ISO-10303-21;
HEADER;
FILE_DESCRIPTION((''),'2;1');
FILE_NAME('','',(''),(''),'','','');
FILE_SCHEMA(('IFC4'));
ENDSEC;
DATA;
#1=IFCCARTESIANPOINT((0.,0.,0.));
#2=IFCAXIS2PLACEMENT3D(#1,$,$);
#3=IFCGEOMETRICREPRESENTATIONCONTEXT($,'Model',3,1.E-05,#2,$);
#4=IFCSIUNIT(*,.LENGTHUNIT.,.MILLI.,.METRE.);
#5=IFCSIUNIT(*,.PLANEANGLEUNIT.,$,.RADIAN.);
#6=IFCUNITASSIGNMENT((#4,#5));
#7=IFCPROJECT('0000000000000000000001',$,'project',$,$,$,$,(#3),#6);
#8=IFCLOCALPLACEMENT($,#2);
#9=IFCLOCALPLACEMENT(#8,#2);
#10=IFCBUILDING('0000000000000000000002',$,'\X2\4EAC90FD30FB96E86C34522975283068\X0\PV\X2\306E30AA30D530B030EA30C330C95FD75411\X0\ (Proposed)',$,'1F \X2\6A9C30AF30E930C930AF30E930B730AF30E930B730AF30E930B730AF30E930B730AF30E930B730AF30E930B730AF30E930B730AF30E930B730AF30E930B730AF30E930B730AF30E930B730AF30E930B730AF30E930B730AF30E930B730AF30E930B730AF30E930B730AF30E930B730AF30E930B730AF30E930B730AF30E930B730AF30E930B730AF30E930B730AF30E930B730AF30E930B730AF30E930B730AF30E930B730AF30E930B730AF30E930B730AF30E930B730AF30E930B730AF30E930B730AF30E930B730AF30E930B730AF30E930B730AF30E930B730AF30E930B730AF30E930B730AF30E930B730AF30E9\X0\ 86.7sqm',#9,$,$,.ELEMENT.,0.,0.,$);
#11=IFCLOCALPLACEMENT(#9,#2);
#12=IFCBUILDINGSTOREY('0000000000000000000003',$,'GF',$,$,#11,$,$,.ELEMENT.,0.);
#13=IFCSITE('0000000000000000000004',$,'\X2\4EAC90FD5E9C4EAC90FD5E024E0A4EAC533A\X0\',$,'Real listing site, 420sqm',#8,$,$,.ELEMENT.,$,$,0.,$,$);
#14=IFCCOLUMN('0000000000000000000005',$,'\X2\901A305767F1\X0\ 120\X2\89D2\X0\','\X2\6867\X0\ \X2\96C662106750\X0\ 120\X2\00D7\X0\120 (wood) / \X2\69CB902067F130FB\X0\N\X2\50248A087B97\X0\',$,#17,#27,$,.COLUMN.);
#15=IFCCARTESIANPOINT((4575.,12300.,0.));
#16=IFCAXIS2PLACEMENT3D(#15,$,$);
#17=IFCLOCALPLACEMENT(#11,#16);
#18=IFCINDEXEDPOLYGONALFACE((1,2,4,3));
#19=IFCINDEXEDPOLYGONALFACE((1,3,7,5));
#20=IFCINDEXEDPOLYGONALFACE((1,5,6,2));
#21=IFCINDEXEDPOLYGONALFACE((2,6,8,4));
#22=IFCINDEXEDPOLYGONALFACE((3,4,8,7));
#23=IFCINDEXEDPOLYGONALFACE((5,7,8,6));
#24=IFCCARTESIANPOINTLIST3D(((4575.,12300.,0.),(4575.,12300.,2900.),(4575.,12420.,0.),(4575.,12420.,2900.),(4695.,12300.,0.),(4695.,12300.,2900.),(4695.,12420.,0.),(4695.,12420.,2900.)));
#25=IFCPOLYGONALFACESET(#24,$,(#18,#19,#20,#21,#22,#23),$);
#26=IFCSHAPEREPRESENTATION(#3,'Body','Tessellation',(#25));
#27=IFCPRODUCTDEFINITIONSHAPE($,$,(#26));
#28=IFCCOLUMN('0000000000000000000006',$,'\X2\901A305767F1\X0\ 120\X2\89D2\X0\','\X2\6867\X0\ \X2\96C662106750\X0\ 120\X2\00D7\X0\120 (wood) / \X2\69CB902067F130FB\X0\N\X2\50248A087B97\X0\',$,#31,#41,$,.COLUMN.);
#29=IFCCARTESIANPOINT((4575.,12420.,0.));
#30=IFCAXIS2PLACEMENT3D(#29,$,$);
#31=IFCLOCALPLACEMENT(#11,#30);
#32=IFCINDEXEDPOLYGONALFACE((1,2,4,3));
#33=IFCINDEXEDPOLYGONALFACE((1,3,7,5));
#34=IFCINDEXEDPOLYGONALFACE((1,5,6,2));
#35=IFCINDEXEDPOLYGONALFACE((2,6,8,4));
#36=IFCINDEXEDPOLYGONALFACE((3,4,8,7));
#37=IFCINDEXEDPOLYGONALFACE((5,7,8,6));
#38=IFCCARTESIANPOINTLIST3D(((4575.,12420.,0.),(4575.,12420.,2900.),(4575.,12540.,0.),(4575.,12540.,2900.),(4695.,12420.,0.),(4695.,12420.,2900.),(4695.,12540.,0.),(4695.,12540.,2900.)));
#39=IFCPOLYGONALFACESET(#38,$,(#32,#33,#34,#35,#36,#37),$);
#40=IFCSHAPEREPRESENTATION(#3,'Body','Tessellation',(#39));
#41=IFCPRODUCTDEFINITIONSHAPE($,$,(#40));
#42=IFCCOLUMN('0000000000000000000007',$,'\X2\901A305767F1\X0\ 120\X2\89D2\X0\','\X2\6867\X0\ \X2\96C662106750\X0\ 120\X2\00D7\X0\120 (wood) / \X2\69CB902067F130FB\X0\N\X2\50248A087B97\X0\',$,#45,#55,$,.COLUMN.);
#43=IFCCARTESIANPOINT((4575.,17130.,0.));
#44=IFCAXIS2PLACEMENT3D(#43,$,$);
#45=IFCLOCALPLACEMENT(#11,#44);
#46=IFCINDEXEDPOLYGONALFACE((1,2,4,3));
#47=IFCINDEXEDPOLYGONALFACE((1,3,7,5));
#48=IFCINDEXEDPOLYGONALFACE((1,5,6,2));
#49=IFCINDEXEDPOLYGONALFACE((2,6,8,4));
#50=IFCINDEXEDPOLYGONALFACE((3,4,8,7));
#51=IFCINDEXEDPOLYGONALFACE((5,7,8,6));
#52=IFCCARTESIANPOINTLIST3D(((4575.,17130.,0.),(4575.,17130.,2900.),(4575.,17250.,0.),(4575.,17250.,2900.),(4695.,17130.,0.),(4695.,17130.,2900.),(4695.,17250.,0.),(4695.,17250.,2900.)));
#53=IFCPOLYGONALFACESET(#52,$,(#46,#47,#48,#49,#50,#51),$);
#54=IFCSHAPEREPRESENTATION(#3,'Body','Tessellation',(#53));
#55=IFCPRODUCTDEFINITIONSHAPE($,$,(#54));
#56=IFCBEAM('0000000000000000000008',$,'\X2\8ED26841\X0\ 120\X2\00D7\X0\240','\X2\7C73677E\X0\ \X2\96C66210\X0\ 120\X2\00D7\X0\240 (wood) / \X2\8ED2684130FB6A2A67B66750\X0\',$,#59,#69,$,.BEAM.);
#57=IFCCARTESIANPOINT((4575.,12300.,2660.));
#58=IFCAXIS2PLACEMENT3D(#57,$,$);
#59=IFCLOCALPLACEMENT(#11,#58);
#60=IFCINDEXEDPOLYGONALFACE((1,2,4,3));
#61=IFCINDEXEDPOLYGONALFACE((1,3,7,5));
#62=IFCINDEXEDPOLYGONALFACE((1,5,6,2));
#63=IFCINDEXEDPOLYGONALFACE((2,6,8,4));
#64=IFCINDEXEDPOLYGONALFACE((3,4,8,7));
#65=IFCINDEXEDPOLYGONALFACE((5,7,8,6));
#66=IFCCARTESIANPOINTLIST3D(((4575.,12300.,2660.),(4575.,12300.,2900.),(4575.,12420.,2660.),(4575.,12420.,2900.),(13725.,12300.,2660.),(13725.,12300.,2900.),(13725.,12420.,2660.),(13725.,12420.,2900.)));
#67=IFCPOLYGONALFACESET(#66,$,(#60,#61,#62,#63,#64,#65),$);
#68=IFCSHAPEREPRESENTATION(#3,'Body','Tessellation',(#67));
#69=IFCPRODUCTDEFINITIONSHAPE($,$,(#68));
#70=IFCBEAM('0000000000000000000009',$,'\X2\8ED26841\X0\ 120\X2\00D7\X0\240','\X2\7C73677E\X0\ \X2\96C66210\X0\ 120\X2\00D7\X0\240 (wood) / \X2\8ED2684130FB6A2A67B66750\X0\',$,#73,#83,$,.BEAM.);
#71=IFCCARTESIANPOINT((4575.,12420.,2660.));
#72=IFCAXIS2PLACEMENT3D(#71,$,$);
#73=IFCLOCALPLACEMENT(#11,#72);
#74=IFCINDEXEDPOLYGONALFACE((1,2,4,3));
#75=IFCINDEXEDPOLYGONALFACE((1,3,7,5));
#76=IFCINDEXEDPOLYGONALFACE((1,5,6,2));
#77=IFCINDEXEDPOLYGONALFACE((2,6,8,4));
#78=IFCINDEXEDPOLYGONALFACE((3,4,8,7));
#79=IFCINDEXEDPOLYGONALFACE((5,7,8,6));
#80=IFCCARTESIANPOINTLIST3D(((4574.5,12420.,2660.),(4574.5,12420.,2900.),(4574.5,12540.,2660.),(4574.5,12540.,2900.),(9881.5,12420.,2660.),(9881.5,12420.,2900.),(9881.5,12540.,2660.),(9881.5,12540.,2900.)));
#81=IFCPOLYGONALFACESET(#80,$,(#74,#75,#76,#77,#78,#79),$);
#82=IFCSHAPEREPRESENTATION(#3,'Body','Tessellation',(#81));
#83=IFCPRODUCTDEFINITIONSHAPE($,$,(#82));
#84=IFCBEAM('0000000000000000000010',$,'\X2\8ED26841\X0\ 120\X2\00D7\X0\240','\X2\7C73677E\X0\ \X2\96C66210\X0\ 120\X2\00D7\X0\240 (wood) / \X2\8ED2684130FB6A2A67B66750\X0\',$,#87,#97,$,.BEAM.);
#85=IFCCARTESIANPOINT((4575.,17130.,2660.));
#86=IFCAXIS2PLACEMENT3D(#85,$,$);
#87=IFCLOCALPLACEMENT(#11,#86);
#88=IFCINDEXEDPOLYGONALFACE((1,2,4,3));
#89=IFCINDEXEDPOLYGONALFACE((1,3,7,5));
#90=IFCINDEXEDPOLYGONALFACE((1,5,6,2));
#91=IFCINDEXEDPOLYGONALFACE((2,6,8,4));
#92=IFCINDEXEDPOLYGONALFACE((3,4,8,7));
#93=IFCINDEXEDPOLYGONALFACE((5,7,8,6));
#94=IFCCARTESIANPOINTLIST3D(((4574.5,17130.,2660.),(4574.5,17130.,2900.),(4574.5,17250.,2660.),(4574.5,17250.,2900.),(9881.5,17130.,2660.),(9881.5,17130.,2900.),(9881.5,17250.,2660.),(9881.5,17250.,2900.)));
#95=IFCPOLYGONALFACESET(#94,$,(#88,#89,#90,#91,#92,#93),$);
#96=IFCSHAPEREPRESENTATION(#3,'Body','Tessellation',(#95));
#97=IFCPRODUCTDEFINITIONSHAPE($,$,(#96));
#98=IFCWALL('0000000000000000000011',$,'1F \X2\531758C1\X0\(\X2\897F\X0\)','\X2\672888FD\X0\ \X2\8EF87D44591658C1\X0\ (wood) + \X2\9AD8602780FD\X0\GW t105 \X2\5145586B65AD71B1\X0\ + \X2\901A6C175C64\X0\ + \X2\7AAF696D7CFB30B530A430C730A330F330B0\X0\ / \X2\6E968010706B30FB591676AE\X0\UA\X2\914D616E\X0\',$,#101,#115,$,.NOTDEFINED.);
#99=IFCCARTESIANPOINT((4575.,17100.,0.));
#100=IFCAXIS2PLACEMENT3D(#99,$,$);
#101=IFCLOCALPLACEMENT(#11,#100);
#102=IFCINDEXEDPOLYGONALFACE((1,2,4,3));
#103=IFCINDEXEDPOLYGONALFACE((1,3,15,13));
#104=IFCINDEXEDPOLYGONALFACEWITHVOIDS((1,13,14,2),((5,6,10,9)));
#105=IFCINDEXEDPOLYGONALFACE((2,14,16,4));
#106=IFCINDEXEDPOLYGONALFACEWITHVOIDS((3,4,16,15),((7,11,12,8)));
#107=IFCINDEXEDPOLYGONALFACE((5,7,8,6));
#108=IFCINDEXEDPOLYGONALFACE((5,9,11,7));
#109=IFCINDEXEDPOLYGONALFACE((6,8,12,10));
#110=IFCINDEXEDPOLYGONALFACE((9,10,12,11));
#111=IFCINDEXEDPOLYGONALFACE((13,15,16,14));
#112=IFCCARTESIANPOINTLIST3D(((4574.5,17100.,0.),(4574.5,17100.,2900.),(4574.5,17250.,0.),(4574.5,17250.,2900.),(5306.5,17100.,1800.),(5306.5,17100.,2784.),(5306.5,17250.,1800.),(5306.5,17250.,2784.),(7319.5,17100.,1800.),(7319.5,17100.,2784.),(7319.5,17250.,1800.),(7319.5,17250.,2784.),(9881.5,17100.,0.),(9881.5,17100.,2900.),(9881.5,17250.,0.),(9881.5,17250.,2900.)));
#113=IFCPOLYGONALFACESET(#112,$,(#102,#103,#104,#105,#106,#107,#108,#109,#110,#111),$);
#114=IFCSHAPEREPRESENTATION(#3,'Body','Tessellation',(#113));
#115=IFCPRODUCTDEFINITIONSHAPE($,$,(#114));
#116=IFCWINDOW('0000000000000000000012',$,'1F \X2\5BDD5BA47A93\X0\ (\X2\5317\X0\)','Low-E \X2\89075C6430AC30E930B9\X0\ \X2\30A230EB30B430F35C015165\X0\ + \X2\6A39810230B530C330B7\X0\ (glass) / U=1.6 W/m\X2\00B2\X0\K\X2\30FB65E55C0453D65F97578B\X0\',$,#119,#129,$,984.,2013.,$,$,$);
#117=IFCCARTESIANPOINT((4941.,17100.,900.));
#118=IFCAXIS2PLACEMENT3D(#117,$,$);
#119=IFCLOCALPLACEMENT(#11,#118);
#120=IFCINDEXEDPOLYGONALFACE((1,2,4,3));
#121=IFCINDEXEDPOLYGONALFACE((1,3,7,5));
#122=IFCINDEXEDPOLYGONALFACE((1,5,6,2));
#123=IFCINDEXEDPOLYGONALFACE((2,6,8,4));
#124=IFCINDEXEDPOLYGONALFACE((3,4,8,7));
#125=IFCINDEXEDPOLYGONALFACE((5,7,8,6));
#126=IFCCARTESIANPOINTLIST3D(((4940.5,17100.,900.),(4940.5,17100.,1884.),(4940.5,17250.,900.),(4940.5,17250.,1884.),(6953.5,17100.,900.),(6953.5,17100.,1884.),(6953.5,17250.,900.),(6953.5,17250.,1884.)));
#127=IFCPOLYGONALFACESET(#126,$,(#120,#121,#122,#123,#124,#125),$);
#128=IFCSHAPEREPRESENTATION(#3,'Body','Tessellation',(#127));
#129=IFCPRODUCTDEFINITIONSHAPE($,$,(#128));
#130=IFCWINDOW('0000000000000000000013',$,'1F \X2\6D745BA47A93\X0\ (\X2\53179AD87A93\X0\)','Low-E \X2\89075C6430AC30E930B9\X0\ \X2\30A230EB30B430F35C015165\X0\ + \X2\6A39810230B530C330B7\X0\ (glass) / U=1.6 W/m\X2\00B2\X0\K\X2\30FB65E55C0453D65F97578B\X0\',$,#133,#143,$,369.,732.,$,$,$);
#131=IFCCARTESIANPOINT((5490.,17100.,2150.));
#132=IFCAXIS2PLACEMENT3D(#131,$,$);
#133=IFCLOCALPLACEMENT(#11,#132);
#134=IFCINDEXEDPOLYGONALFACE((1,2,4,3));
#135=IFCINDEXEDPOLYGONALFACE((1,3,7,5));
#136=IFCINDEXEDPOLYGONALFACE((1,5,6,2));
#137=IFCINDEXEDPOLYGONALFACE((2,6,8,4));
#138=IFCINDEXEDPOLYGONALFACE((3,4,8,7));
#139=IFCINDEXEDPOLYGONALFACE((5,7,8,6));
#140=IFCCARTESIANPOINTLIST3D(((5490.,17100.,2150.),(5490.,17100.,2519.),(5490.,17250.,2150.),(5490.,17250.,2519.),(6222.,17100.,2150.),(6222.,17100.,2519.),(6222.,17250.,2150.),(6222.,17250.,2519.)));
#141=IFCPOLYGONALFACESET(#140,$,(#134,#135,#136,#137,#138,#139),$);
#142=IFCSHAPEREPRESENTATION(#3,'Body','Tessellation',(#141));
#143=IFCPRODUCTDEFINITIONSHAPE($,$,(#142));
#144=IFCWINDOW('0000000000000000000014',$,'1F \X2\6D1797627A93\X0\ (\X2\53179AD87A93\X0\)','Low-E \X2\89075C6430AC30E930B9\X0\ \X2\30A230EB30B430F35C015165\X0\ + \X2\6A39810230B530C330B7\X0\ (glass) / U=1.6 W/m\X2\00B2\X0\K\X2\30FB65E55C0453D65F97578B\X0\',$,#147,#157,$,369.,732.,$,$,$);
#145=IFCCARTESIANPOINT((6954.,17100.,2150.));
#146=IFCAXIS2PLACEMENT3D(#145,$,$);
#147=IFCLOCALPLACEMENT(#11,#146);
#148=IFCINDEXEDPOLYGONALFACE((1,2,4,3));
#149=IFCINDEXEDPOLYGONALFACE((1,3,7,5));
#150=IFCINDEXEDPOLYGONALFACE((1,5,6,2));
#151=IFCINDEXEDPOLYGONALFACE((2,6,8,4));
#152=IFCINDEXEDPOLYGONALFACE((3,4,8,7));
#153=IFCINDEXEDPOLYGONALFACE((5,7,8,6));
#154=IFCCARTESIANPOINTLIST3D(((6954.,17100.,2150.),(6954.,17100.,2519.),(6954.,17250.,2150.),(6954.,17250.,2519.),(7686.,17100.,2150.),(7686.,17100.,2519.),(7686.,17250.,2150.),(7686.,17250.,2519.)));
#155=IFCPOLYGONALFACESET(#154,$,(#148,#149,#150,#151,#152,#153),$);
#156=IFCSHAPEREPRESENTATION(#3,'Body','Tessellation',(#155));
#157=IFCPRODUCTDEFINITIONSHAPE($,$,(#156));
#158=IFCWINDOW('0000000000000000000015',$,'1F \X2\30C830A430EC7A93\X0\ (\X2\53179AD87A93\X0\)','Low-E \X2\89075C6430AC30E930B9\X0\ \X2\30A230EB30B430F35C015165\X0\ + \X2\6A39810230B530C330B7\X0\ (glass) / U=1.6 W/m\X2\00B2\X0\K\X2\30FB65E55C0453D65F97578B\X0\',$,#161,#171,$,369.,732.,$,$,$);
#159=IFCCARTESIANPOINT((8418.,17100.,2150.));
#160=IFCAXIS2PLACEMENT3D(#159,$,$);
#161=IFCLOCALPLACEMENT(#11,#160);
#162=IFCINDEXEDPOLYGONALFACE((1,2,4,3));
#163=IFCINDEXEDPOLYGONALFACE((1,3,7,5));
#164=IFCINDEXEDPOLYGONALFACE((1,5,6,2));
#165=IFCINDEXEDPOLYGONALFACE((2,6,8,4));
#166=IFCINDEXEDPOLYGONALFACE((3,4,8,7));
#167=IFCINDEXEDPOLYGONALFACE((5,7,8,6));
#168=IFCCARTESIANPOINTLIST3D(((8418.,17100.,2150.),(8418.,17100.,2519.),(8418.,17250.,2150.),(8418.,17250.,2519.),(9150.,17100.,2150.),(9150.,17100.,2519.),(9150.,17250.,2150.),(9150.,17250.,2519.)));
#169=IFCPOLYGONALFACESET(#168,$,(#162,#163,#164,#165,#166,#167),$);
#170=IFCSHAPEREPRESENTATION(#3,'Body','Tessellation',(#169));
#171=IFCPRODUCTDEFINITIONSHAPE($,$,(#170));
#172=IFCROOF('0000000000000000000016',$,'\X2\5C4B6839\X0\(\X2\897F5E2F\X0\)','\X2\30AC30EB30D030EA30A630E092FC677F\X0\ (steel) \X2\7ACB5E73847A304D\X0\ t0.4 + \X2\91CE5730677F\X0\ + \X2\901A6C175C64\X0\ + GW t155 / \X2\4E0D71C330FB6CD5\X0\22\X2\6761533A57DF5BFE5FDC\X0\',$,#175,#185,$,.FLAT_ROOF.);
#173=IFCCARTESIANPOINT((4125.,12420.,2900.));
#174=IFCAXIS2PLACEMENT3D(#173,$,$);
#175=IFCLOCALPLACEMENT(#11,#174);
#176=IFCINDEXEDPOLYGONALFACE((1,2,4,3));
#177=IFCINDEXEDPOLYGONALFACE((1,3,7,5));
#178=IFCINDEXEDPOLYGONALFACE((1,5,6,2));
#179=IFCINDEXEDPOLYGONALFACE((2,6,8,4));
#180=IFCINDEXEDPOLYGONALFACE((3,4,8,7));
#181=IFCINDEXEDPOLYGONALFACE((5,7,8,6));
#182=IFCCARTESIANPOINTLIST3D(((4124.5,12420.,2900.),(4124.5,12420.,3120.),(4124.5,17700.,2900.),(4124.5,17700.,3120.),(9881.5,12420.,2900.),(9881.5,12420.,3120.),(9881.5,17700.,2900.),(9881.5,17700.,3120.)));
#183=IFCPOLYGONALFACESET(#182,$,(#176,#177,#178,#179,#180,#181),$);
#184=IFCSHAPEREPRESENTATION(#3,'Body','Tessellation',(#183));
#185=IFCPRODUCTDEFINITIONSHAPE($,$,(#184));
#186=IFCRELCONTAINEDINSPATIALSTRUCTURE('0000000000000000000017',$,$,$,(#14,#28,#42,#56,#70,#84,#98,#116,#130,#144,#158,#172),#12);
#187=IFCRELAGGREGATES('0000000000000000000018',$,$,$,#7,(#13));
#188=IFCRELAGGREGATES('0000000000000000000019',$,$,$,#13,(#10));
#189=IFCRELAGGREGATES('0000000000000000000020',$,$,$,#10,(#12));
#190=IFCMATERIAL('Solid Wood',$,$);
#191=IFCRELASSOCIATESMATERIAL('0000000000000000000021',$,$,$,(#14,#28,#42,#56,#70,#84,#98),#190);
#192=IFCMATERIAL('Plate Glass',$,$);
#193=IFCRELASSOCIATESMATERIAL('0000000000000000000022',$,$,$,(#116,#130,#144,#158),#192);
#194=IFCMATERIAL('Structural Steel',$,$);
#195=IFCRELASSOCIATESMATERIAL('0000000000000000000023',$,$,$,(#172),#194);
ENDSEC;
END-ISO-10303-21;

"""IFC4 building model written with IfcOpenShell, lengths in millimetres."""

from ifc_helpers import new_model, si_unit, frame, frame_2d, origin, place, context, project, spatial, rectangle, extrude, material, element, fill, save


model = new_model("IFC4")

# Units and contexts
model_context = context("Model", 3, precision=1e-05, world=origin())
ifc_project = project(units=[si_unit("LENGTHUNIT", "METRE", prefix="MILLI"), si_unit("PLANEANGLEUNIT", "RADIAN")], contexts=[model_context])

# Site, building, storey
site_placement = place(None, origin())
site = spatial("IfcSite", under=ifc_project, at=site_placement, Name="京都府京都市上京区", ObjectType="Real listing site, 420sqm", CompositionType="ELEMENT", RefElevation=0.0)
building_placement = place(site_placement, origin())
building = spatial("IfcBuilding", under=site, at=building_placement, Name="京都・雨水利用とPVのオフグリッド志向 (Proposed)", ObjectType="1F 檜クラドクラシクラシクラシクラシクラシクラシクラシクラシクラシクラシクラシクラシクラシクラシクラシクラシクラシクラシクラシクラシクラシクラシクラシクラシクラシクラシクラシクラシクラシクラシクラシクラシクラシクラシクラシクラシクラシクラシクラ 86.7sqm", CompositionType="ELEMENT", ElevationOfRefHeight=0.0, ElevationOfTerrain=0.0)
storey_placement = place(building_placement, origin())
storey = spatial("IfcBuildingStorey", under=building, at=storey_placement, Name="GF", CompositionType="ELEMENT", Elevation=0.0)

# Columns
ifc_material_1 = material(Name="Solid Wood")
column_1_placement = place(storey_placement, frame((4575.0, 12300.0, 0.0)))
element("IfcColumn", 1, at=column_1_placement, inside=storey, material=ifc_material_1, Name="通し柱 120角", Description="桧 集成材 120×120 (wood) / 構造柱・N値計算", PredefinedType="COLUMN", context=model_context, shape_type="SweptSolid", body=[
    extrude(rectangle(XDim=120.0, YDim=120.0, at=frame_2d((60.0, 60.0))), frame((4575.0, 12300.0, 0.0)), (0.0, 0.0, 1.0), 2900.0),
])
column_2_placement = place(storey_placement, frame((4575.0, 12420.0, 0.0)))
element("IfcColumn", 2, at=column_2_placement, inside=storey, material=ifc_material_1, Name="通し柱 120角", Description="桧 集成材 120×120 (wood) / 構造柱・N値計算", PredefinedType="COLUMN", context=model_context, shape_type="SweptSolid", body=[
    extrude(rectangle(XDim=120.0, YDim=120.0, at=frame_2d((60.0, 60.0))), frame((4575.0, 12420.0, 0.0)), (0.0, 0.0, 1.0), 2900.0),
])
column_3_placement = place(storey_placement, frame((4575.0, 17130.0, 0.0)))
element("IfcColumn", 3, at=column_3_placement, inside=storey, material=ifc_material_1, Name="通し柱 120角", Description="桧 集成材 120×120 (wood) / 構造柱・N値計算", PredefinedType="COLUMN", context=model_context, shape_type="SweptSolid", body=[
    extrude(rectangle(XDim=120.0, YDim=120.0, at=frame_2d((60.0, 60.0))), frame((4575.0, 17130.0, 0.0)), (0.0, 0.0, 1.0), 2900.0),
])

# Beams
beam_1_placement = place(storey_placement, frame((4575.0, 12300.0, 2660.0)))
element("IfcBeam", 4, at=beam_1_placement, inside=storey, material=ifc_material_1, Name="軒桁 120×240", Description="米松 集成 120×240 (wood) / 軒桁・横架材", PredefinedType="BEAM", context=model_context, shape_type="SweptSolid", body=[
    extrude(rectangle(XDim=9150.0, YDim=120.0, at=frame_2d((4575.0, 60.0))), frame((4575.0, 12300.0, 2660.0)), (0.0, 0.0, 1.0), 240.0),
])
beam_2_placement = place(storey_placement, frame((4575.0, 12420.0, 2660.0)))
element("IfcBeam", 5, at=beam_2_placement, inside=storey, material=ifc_material_1, Name="軒桁 120×240", Description="米松 集成 120×240 (wood) / 軒桁・横架材", PredefinedType="BEAM", context=model_context, shape_type="SweptSolid", body=[
    extrude(rectangle(XDim=5307.0, YDim=120.0, at=frame_2d((2653.0, 60.0))), frame((4575.0, 12420.0, 2660.0)), (0.0, 0.0, 1.0), 240.0),
])
beam_3_placement = place(storey_placement, frame((4575.0, 17130.0, 2660.0)))
element("IfcBeam", 6, at=beam_3_placement, inside=storey, material=ifc_material_1, Name="軒桁 120×240", Description="米松 集成 120×240 (wood) / 軒桁・横架材", PredefinedType="BEAM", context=model_context, shape_type="SweptSolid", body=[
    extrude(rectangle(XDim=5307.0, YDim=120.0, at=frame_2d((2653.0, 60.0))), frame((4575.0, 17130.0, 2660.0)), (0.0, 0.0, 1.0), 240.0),
])

# Wall, openings, windows
wall_1_placement = place(storey_placement, frame((4575.0, 17100.0, 0.0)))
wall_1 = element("IfcWall", 7, at=wall_1_placement, inside=storey, material=ifc_material_1, Name="1F 北壁(西)", Description="木製 軸組外壁 (wood) + 高性能GW t105 充填断熱 + 通気層 + 窯業系サイディング / 準耐火・外皮UA配慮", PredefinedType="NOTDEFINED", context=model_context, shape_type="SweptSolid", body=[
    extrude(rectangle(XDim=5307.0, YDim=150.0, at=frame_2d((2653.0, 75.0))), frame((4575.0, 17100.0, 0.0)), (0.0, 0.0, 1.0), 2900.0),
])
opening_1_placement = place(storey_placement, frame((4941.0, 17100.0, 900.0)))
opening_1 = element("IfcOpeningElement", 8, at=opening_1_placement, cuts=wall_1, PredefinedType="NOTDEFINED", context=model_context, shape_type="SweptSolid", body=[
    extrude(rectangle(XDim=2013.0, YDim=150.0, at=frame_2d((1006.0, 75.0))), frame((4941.0, 17100.0, 900.0)), (0.0, 0.0, 1.0), 984.0),
])
opening_2_placement = place(storey_placement, frame((5490.0, 17100.0, 2150.0)))
opening_2 = element("IfcOpeningElement", 9, at=opening_2_placement, cuts=wall_1, PredefinedType="NOTDEFINED", context=model_context, shape_type="SweptSolid", body=[
    extrude(rectangle(XDim=732.0, YDim=150.0, at=frame_2d((366.0, 75.0))), frame((5490.0, 17100.0, 2150.0)), (0.0, 0.0, 1.0), 369.0),
])
opening_3_placement = place(storey_placement, frame((6954.0, 17100.0, 2150.0)))
opening_3 = element("IfcOpeningElement", 10, at=opening_3_placement, cuts=wall_1, PredefinedType="NOTDEFINED", context=model_context, shape_type="SweptSolid", body=[
    extrude(rectangle(XDim=732.0, YDim=150.0, at=frame_2d((366.0, 75.0))), frame((6954.0, 17100.0, 2150.0)), (0.0, 0.0, 1.0), 369.0),
])
opening_4_placement = place(storey_placement, frame((8418.0, 17100.0, 2150.0)))
opening_4 = element("IfcOpeningElement", 11, at=opening_4_placement, cuts=wall_1, PredefinedType="NOTDEFINED", context=model_context, shape_type="SweptSolid", body=[
    extrude(rectangle(XDim=732.0, YDim=150.0, at=frame_2d((366.0, 75.0))), frame((8418.0, 17100.0, 2150.0)), (0.0, 0.0, 1.0), 369.0),
])
ifc_material_2 = material(Name="Plate Glass")
window_1_placement = place(storey_placement, frame((4941.0, 17100.0, 900.0)))
window_1 = element("IfcWindow", 12, at=window_1_placement, inside=storey, material=ifc_material_2, Name="1F 寝室窓 (北)", Description="Low-E 複層ガラス アルゴン封入 + 樹脂サッシ (glass) / U=1.6 W/m²K・日射取得型", OverallHeight=984.0, OverallWidth=2013.0, context=model_context, shape_type="SweptSolid", body=[
    extrude(rectangle(XDim=2013.0, YDim=150.0, at=frame_2d((1006.0, 75.0))), frame((4941.0, 17100.0, 900.0)), (0.0, 0.0, 1.0), 984.0),
])
fill(opening_1, window_1)
window_2_placement = place(storey_placement, frame((5490.0, 17100.0, 2150.0)))
window_2 = element("IfcWindow", 13, at=window_2_placement, inside=storey, material=ifc_material_2, Name="1F 浴室窓 (北高窓)", Description="Low-E 複層ガラス アルゴン封入 + 樹脂サッシ (glass) / U=1.6 W/m²K・日射取得型", OverallHeight=369.0, OverallWidth=732.0, context=model_context, shape_type="SweptSolid", body=[
    extrude(rectangle(XDim=732.0, YDim=150.0, at=frame_2d((366.0, 75.0))), frame((5490.0, 17100.0, 2150.0)), (0.0, 0.0, 1.0), 369.0),
])
fill(opening_2, window_2)
window_3_placement = place(storey_placement, frame((6954.0, 17100.0, 2150.0)))
window_3 = element("IfcWindow", 14, at=window_3_placement, inside=storey, material=ifc_material_2, Name="1F 洗面窓 (北高窓)", Description="Low-E 複層ガラス アルゴン封入 + 樹脂サッシ (glass) / U=1.6 W/m²K・日射取得型", OverallHeight=369.0, OverallWidth=732.0, context=model_context, shape_type="SweptSolid", body=[
    extrude(rectangle(XDim=732.0, YDim=150.0, at=frame_2d((366.0, 75.0))), frame((6954.0, 17100.0, 2150.0)), (0.0, 0.0, 1.0), 369.0),
])
fill(opening_3, window_3)
window_4_placement = place(storey_placement, frame((8418.0, 17100.0, 2150.0)))
window_4 = element("IfcWindow", 15, at=window_4_placement, inside=storey, material=ifc_material_2, Name="1F トイレ窓 (北高窓)", Description="Low-E 複層ガラス アルゴン封入 + 樹脂サッシ (glass) / U=1.6 W/m²K・日射取得型", OverallHeight=369.0, OverallWidth=732.0, context=model_context, shape_type="SweptSolid", body=[
    extrude(rectangle(XDim=732.0, YDim=150.0, at=frame_2d((366.0, 75.0))), frame((8418.0, 17100.0, 2150.0)), (0.0, 0.0, 1.0), 369.0),
])
fill(opening_4, window_4)

# Roof
ifc_material_3 = material(Name="Structural Steel")
roof_placement = place(storey_placement, frame((4125.0, 12420.0, 2900.0)))
element("IfcRoof", 16, at=roof_placement, inside=storey, material=ifc_material_3, Name="屋根(西帯)", Description="ガルバリウム鋼板 (steel) 立平葺き t0.4 + 野地板 + 通気層 + GW t155 / 不燃・法22条区域対応", PredefinedType="FLAT_ROOF", context=model_context, shape_type="SweptSolid", body=[
    extrude(rectangle(XDim=5757.0, YDim=5280.0, at=frame_2d((2878.0, 2640.0))), frame((4125.0, 12420.0, 2900.0)), (0.0, 0.0, 1.0), 220.0),
])

save(model, "model.ifc")
